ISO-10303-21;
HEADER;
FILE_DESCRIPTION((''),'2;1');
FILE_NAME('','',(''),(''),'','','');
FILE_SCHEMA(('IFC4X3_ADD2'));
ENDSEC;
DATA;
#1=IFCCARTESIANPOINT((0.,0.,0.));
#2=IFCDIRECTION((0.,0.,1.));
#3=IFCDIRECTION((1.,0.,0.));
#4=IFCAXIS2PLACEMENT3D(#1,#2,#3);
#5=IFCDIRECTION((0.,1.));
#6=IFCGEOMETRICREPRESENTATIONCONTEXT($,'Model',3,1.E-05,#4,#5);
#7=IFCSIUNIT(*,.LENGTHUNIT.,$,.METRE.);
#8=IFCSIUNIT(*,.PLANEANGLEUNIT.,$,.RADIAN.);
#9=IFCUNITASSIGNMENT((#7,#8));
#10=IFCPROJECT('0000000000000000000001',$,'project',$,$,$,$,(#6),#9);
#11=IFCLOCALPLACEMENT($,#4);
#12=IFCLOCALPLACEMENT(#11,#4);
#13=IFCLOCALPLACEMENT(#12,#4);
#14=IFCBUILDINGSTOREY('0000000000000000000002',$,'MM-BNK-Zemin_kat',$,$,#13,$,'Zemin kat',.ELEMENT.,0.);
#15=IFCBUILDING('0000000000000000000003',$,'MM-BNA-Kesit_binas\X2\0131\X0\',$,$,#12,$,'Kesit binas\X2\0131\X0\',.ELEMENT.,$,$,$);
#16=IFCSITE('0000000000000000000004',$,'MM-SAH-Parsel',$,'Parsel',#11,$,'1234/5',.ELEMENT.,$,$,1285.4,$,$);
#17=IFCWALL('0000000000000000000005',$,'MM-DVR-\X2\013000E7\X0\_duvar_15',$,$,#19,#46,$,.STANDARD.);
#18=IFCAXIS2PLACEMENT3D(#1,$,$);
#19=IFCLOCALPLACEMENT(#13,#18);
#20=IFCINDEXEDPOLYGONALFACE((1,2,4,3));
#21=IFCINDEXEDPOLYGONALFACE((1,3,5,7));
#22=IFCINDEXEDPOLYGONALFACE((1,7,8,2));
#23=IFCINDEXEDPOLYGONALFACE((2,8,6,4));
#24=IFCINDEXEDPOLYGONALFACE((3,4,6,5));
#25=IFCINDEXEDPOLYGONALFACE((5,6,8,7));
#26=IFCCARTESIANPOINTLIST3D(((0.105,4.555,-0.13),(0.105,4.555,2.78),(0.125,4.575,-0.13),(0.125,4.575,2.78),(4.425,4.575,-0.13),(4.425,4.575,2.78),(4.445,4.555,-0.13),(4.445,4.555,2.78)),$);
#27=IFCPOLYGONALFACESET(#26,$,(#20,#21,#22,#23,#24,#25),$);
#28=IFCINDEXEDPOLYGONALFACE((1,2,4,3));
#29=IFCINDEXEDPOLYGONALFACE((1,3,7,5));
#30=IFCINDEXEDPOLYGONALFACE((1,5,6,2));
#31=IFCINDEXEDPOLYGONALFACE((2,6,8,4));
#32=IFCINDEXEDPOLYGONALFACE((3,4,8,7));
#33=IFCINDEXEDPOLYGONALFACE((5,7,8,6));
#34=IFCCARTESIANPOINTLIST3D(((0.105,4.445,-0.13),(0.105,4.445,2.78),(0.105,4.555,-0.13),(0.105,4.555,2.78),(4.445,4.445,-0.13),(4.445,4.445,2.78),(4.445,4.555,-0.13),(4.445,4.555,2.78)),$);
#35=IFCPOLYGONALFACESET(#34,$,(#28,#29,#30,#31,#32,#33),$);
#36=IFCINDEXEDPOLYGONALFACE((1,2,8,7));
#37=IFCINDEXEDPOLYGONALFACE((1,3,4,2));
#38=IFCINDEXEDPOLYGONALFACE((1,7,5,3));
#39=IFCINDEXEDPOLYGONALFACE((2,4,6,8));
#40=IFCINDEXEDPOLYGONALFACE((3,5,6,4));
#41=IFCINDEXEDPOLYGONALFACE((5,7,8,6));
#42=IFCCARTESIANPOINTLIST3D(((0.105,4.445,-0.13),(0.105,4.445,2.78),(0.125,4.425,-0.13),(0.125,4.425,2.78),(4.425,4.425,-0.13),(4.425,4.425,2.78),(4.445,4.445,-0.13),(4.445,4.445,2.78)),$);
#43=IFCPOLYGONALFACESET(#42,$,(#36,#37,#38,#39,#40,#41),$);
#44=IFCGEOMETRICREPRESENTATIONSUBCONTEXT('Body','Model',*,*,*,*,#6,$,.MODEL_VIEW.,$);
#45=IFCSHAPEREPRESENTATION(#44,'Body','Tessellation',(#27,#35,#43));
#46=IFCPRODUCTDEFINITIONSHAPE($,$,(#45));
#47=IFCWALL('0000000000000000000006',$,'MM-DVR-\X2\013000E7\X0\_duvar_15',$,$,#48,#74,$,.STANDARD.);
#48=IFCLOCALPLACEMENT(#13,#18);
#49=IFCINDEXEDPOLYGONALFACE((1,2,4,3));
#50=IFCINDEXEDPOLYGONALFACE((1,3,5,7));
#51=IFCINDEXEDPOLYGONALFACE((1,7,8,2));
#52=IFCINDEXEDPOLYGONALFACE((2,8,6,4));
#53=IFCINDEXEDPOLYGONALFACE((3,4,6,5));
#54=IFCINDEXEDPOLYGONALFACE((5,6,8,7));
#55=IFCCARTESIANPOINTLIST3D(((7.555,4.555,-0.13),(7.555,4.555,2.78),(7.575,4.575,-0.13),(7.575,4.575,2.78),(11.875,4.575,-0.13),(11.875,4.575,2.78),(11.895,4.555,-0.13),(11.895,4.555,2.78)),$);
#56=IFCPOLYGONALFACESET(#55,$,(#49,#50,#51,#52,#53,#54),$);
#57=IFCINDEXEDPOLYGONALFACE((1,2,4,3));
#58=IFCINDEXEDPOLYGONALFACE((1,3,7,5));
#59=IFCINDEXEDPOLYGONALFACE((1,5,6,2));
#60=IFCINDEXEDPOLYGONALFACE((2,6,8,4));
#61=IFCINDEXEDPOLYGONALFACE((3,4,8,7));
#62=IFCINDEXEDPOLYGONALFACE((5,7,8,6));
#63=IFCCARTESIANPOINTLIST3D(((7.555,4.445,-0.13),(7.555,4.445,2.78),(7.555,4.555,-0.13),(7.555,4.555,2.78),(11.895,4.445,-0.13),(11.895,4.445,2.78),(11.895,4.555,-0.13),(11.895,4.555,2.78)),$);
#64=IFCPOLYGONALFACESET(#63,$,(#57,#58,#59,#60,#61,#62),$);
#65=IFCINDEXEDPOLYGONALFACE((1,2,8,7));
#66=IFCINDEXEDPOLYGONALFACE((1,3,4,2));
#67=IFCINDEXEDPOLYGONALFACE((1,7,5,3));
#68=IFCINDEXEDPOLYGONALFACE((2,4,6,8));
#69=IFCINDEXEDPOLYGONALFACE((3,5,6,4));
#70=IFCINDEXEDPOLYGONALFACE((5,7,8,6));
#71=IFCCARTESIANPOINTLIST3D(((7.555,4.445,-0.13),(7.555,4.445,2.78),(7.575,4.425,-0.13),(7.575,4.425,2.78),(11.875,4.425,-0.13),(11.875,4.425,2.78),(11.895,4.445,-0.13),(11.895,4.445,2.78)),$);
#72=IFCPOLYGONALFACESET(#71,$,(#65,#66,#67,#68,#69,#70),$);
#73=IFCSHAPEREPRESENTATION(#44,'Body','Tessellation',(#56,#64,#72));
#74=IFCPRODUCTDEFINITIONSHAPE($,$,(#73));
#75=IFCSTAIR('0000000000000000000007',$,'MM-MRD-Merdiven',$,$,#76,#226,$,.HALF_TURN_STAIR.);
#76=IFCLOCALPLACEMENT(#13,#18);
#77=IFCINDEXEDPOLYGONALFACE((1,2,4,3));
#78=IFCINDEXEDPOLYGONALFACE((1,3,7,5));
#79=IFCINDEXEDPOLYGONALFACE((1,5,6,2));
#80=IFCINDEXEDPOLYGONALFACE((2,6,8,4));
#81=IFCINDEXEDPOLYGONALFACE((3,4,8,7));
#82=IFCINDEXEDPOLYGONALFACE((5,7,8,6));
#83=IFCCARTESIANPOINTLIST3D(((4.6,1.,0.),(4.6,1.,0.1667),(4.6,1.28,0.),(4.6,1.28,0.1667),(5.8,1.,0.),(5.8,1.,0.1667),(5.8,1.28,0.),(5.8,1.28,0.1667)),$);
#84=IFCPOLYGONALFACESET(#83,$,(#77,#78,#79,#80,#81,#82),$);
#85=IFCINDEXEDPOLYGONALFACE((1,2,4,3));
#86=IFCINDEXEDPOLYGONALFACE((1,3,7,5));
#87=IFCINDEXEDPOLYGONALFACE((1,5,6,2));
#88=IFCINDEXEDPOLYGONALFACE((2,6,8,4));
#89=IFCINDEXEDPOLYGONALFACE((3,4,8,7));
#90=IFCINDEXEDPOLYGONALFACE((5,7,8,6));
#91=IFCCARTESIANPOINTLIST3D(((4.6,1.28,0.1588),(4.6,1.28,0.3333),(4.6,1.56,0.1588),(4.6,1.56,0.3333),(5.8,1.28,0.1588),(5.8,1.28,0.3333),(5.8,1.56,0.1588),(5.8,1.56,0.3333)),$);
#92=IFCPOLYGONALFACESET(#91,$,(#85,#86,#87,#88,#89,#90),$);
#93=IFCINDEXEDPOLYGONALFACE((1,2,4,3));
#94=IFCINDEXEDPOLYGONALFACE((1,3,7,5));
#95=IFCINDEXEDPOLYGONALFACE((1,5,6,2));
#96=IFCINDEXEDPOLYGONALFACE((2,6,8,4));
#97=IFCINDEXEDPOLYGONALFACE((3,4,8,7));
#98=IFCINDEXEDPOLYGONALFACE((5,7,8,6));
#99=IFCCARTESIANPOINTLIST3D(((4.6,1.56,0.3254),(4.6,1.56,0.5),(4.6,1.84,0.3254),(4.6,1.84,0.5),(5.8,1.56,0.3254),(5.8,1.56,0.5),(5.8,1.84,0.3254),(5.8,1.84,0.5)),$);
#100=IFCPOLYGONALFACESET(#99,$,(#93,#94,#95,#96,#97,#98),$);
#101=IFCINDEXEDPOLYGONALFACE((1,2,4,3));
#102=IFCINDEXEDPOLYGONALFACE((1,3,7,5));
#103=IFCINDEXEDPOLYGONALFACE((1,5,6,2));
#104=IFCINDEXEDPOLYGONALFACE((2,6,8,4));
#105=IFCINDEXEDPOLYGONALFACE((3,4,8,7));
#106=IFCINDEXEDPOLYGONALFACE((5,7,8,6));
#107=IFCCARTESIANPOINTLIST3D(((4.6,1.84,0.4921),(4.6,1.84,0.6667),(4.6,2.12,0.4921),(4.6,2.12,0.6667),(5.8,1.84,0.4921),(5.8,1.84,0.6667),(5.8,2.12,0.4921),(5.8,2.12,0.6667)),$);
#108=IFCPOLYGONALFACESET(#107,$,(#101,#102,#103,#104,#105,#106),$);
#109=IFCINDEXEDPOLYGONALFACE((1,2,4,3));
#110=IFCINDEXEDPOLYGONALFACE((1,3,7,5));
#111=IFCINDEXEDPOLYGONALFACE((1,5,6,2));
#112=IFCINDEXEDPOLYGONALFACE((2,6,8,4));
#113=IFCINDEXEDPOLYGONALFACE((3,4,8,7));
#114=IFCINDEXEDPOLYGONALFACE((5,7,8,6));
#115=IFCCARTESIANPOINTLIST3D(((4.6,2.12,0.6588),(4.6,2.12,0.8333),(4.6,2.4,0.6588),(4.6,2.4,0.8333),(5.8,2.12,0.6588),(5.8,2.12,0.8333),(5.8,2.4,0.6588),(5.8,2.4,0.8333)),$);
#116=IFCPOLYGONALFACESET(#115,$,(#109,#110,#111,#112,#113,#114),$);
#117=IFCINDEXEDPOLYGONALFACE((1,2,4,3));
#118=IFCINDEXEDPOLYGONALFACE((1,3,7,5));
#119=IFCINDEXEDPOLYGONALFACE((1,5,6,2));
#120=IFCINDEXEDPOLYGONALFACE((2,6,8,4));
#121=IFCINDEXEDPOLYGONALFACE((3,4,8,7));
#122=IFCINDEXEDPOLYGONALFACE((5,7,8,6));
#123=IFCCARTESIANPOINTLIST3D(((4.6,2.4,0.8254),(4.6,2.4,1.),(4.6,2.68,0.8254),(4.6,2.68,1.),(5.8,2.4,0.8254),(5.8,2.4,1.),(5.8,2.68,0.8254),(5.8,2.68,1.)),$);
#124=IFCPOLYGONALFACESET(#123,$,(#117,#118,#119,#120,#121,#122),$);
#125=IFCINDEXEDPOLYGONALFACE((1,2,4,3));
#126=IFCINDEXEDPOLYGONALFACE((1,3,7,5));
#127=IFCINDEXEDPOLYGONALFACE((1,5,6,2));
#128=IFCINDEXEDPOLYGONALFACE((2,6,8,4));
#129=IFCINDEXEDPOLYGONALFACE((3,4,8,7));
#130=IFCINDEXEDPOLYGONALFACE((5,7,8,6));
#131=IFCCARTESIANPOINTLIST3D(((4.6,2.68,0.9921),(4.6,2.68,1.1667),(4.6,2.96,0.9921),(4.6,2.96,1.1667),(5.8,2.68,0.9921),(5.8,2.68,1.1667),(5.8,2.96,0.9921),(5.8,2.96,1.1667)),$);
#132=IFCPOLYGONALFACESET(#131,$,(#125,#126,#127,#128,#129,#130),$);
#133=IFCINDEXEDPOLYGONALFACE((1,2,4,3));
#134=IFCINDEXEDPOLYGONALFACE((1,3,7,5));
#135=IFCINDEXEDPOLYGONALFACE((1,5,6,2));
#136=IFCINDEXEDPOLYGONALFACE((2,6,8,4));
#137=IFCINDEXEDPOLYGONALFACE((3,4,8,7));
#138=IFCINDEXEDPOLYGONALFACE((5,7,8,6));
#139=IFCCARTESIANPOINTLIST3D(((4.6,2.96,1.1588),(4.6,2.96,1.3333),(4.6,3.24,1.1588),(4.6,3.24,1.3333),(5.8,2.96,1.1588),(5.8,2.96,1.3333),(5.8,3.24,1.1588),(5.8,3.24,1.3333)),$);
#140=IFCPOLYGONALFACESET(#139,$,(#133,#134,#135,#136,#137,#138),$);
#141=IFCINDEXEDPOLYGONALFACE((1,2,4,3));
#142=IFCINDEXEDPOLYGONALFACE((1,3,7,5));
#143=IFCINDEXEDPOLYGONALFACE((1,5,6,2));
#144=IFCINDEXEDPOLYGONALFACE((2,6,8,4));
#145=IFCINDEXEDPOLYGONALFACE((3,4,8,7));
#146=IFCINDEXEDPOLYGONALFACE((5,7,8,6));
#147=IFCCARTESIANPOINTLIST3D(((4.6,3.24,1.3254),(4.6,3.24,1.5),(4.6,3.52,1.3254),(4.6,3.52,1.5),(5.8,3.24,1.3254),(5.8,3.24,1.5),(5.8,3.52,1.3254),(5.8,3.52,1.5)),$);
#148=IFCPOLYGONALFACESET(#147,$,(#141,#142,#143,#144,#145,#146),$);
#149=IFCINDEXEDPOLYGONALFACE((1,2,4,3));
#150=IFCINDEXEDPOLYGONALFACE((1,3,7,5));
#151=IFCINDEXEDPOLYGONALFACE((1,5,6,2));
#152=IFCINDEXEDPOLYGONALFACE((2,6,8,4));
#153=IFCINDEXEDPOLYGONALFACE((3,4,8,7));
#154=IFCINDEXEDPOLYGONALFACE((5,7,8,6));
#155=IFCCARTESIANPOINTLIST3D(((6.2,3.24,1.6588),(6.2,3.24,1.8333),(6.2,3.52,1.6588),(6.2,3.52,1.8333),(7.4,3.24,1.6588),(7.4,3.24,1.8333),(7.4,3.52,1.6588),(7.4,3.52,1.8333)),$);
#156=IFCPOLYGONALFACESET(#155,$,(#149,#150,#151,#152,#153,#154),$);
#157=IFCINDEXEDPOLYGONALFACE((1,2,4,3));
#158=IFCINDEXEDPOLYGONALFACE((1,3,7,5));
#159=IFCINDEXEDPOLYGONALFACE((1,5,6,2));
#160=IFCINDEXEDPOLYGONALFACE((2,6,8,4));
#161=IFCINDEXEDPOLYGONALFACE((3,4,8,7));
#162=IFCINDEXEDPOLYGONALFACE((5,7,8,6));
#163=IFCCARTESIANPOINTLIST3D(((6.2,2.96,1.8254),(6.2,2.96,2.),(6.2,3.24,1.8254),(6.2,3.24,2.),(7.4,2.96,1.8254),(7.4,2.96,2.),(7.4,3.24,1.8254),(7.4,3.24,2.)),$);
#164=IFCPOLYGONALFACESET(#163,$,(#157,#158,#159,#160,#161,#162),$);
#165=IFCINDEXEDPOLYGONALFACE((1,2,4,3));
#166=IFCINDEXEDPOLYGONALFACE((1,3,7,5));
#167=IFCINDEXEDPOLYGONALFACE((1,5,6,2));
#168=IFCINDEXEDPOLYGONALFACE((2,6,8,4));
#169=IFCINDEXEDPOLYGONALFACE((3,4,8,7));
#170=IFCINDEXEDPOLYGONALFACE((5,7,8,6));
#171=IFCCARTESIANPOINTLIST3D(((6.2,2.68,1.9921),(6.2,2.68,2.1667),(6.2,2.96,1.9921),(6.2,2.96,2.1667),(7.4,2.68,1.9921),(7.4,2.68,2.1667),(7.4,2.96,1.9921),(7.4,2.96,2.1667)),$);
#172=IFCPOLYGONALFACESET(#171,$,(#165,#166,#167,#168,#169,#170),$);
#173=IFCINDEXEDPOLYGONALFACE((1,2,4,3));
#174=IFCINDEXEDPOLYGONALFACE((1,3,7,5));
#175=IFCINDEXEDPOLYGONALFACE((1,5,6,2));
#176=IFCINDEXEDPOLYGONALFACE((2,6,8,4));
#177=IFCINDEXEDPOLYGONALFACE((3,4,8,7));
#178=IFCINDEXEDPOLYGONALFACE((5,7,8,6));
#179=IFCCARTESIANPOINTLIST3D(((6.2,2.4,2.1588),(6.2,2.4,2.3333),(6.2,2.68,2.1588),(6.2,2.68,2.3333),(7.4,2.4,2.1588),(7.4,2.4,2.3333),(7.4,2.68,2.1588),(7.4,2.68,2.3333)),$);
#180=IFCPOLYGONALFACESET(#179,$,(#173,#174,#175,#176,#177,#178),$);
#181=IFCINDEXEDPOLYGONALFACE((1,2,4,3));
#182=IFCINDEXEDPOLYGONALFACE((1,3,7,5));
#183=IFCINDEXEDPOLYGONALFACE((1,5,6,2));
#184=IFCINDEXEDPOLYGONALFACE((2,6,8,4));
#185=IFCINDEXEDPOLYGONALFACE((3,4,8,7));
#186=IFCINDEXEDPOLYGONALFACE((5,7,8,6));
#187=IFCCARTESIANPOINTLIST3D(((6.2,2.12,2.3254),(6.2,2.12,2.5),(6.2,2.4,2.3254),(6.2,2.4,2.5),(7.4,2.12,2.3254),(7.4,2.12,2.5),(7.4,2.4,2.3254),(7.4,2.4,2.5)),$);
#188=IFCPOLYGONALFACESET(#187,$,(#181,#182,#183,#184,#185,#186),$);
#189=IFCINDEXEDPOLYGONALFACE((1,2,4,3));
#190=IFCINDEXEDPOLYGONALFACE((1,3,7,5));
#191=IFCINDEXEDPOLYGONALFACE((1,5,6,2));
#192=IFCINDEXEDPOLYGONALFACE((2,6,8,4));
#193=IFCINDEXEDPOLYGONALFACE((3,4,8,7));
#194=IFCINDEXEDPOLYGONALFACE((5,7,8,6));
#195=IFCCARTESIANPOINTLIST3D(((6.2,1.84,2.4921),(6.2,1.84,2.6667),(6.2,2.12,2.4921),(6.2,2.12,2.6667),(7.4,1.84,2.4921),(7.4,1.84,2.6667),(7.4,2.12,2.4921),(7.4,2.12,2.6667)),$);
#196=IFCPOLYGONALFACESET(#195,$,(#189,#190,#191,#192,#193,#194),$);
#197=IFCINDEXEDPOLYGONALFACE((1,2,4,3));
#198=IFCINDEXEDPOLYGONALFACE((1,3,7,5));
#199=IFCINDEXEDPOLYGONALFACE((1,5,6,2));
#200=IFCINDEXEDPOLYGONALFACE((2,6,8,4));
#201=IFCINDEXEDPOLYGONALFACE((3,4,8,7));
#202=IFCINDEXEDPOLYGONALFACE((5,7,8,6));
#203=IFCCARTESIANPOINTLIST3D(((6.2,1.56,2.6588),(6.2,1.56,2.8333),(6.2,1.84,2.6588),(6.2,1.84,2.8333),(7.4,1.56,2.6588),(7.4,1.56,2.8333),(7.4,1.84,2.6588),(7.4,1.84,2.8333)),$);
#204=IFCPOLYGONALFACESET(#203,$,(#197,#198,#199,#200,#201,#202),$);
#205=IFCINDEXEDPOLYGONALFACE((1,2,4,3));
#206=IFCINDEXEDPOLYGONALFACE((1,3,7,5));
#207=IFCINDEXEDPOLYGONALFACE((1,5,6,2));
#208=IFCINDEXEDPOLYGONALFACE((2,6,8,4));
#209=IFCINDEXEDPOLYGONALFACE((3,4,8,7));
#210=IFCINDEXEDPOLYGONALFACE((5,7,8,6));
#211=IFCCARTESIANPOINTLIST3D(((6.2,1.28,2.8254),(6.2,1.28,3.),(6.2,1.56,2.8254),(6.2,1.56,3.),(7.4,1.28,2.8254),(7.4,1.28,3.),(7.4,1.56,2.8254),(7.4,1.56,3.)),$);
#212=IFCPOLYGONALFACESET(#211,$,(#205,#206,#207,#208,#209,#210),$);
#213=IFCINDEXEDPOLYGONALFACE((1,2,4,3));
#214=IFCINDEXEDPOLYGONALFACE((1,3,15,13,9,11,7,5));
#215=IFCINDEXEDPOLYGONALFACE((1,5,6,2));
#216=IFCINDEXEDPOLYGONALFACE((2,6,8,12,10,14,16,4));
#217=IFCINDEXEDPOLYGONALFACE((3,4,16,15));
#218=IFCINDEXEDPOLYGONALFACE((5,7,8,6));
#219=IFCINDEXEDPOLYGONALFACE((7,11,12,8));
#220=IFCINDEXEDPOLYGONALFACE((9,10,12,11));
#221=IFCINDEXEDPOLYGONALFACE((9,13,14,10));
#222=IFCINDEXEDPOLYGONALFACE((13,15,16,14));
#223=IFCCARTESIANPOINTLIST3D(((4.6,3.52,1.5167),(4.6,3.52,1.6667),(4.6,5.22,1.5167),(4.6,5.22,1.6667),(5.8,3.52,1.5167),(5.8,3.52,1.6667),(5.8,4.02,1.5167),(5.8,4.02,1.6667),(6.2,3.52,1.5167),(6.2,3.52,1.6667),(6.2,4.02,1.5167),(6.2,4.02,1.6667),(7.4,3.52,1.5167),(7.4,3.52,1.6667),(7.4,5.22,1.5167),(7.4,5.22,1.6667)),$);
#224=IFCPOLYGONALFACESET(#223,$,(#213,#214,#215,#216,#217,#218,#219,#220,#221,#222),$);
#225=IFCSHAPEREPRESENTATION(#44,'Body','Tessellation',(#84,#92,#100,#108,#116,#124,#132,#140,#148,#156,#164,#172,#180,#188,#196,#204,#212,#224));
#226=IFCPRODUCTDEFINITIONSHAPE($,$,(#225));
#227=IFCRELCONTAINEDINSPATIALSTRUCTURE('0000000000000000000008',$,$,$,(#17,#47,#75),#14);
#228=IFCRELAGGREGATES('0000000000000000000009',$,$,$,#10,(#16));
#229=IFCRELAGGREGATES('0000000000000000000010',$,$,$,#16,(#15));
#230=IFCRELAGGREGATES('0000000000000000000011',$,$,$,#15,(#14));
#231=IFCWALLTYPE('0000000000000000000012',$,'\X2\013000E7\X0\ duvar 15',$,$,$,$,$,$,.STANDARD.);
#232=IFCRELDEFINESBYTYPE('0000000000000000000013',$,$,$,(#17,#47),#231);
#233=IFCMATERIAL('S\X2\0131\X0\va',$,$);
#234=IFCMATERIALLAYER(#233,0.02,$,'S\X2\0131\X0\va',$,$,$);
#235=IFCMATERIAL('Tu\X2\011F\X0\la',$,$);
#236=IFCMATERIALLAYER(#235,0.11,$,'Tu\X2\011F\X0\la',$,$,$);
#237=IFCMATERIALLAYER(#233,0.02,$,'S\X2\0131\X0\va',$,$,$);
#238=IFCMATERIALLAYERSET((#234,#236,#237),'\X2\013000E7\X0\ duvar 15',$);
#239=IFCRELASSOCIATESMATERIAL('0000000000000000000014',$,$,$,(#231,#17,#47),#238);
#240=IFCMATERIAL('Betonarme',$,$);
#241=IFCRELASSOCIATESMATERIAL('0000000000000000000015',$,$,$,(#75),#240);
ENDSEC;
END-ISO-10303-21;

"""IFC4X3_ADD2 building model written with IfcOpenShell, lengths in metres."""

from ifc_helpers import new_model, si_unit, direction, frame, origin, origin_with_axes, place, context, subcontext, project, spatial, polyline, outline, extrude, material, layer, layer_set, type_object, element, save


model = new_model("IFC4X3_ADD2")

# Units and contexts
model_context = context("Model", 3, precision=1e-05, world=origin_with_axes(), true_north=direction((0.0, 1.0)))
body_context = subcontext(model_context, "Body", "Model", "MODEL_VIEW")
ifc_project = project(units=[si_unit("LENGTHUNIT", "METRE"), si_unit("PLANEANGLEUNIT", "RADIAN")], contexts=[model_context])

# Site, building, storey
site_placement = place(None, origin_with_axes())
site = spatial("IfcSite", under=ifc_project, at=site_placement, Name="MM-SAH-Parsel", ObjectType="Parsel", LongName="1234/5", CompositionType="ELEMENT", RefElevation=1285.4)
building_placement = place(site_placement, origin_with_axes())
building = spatial("IfcBuilding", under=site, at=building_placement, Name="MM-BNA-Kesit_binası", LongName="Kesit binası", CompositionType="ELEMENT")
storey_placement = place(building_placement, origin_with_axes())
storey = spatial("IfcBuildingStorey", under=building, at=storey_placement, Name="MM-BNK-Zemin_kat", LongName="Zemin kat", CompositionType="ELEMENT", Elevation=0.0)

# Shared definitions
ifc_material_1 = material(Name="Betonarme")

# Shared definitions
ifc_material_2 = material(Name="Tuğla")

# Shared definitions
ifc_material_3 = material(Name="Sıva")
ifc_layer_1 = layer(ifc_material_3, 0.02, Name="Sıva")
ifc_layer_2 = layer(ifc_material_2, 0.11, Name="Tuğla")
ifc_layer_3 = layer(ifc_material_3, 0.02, Name="Sıva")
ifc_layer_set_1 = layer_set([ifc_layer_1, ifc_layer_2, ifc_layer_3], Name="İç duvar 15")
wall_type_1 = type_object("IfcWallType", Name="İç duvar 15", PredefinedType="STANDARD", material=ifc_layer_set_1)

# Walls
wall_1_placement = place(storey_placement, origin_with_axes())
element("IfcWall", 1, at=wall_1_placement, inside=storey, type_object=wall_type_1, material=ifc_layer_set_1, Name="MM-DVR-İç_duvar_15", PredefinedType="STANDARD", context=body_context, shape_type="SweptSolid", body=[
    extrude(outline(polyline([(0.125, 4.575), (4.425, 4.575), (4.445, 4.555), (0.105, 4.555), (0.125, 4.575)])), frame((0.0, 0.0, -0.13)), (0.0, 0.0, 1.0), 2.91),
    extrude(outline(polyline([(0.105, 4.555), (4.445, 4.555), (4.445, 4.445), (0.105, 4.445), (0.105, 4.555)])), frame((0.0, 0.0, -0.13)), (0.0, 0.0, 1.0), 2.91),
    extrude(outline(polyline([(0.105, 4.445), (4.445, 4.445), (4.425, 4.425), (0.125, 4.425), (0.105, 4.445)])), frame((0.0, 0.0, -0.13)), (0.0, 0.0, 1.0), 2.91),
])
wall_2_placement = place(storey_placement, origin_with_axes())
element("IfcWall", 2, at=wall_2_placement, inside=storey, type_object=wall_type_1, material=ifc_layer_set_1, Name="MM-DVR-İç_duvar_15", PredefinedType="STANDARD", context=body_context, shape_type="SweptSolid", body=[
    extrude(outline(polyline([(7.575, 4.575), (11.875, 4.575), (11.895, 4.555), (7.555, 4.555), (7.575, 4.575)])), frame((0.0, 0.0, -0.13)), (0.0, 0.0, 1.0), 2.91),
    extrude(outline(polyline([(7.555, 4.555), (11.895, 4.555), (11.895, 4.445), (7.555, 4.445), (7.555, 4.555)])), frame((0.0, 0.0, -0.13)), (0.0, 0.0, 1.0), 2.91),
    extrude(outline(polyline([(7.555, 4.445), (11.895, 4.445), (11.875, 4.425), (7.575, 4.425), (7.555, 4.445)])), frame((0.0, 0.0, -0.13)), (0.0, 0.0, 1.0), 2.91),
])

# Stair
stair_placement = place(storey_placement, origin_with_axes())
element("IfcStair", 3, at=stair_placement, inside=storey, material=ifc_material_1, Name="MM-MRD-Merdiven", PredefinedType="HALF_TURN_STAIR", context=body_context, shape_type="SweptSolid", body=[
    extrude(outline(polyline([(5.8, 1.0), (5.8, 1.28), (4.6, 1.28), (4.6, 1.0), (5.8, 1.0)])), origin(), (0.0, 0.0, 1.0), 0.1667),
    extrude(outline(polyline([(5.8, 1.28), (5.8, 1.56), (4.6, 1.56), (4.6, 1.28), (5.8, 1.28)])), frame((0.0, 0.0, 0.1588)), (0.0, 0.0, 1.0), 0.1746),
    extrude(outline(polyline([(5.8, 1.56), (5.8, 1.84), (4.6, 1.84), (4.6, 1.56), (5.8, 1.56)])), frame((0.0, 0.0, 0.3254)), (0.0, 0.0, 1.0), 0.1746),
    extrude(outline(polyline([(5.8, 1.84), (5.8, 2.12), (4.6, 2.12), (4.6, 1.84), (5.8, 1.84)])), frame((0.0, 0.0, 0.4921)), (0.0, 0.0, 1.0), 0.1746),
    extrude(outline(polyline([(5.8, 2.12), (5.8, 2.4), (4.6, 2.4), (4.6, 2.12), (5.8, 2.12)])), frame((0.0, 0.0, 0.6588)), (0.0, 0.0, 1.0), 0.1746),
    extrude(outline(polyline([(5.8, 2.4), (5.8, 2.68), (4.6, 2.68), (4.6, 2.4), (5.8, 2.4)])), frame((0.0, 0.0, 0.8254)), (0.0, 0.0, 1.0), 0.1746),
    extrude(outline(polyline([(5.8, 2.68), (5.8, 2.96), (4.6, 2.96), (4.6, 2.68), (5.8, 2.68)])), frame((0.0, 0.0, 0.9921)), (0.0, 0.0, 1.0), 0.1746),
    extrude(outline(polyline([(5.8, 2.96), (5.8, 3.24), (4.6, 3.24), (4.6, 2.96), (5.8, 2.96)])), frame((0.0, 0.0, 1.1588)), (0.0, 0.0, 1.0), 0.1746),
    extrude(outline(polyline([(5.8, 3.24), (5.8, 3.52), (4.6, 3.52), (4.6, 3.24), (5.8, 3.24)])), frame((0.0, 0.0, 1.3254)), (0.0, 0.0, 1.0), 0.1746),
    extrude(outline(polyline([(6.2, 3.52), (6.2, 3.24), (7.4, 3.24), (7.4, 3.52), (6.2, 3.52)])), frame((0.0, 0.0, 1.6588)), (0.0, 0.0, 1.0), 0.1746),
    extrude(outline(polyline([(6.2, 3.24), (6.2, 2.96), (7.4, 2.96), (7.4, 3.24), (6.2, 3.24)])), frame((0.0, 0.0, 1.8254)), (0.0, 0.0, 1.0), 0.1746),
    extrude(outline(polyline([(6.2, 2.96), (6.2, 2.68), (7.4, 2.68), (7.4, 2.96), (6.2, 2.96)])), frame((0.0, 0.0, 1.9921)), (0.0, 0.0, 1.0), 0.1746),
    extrude(outline(polyline([(6.2, 2.68), (6.2, 2.4), (7.4, 2.4), (7.4, 2.68), (6.2, 2.68)])), frame((0.0, 0.0, 2.1588)), (0.0, 0.0, 1.0), 0.1746),
    extrude(outline(polyline([(6.2, 2.4), (6.2, 2.12), (7.4, 2.12), (7.4, 2.4), (6.2, 2.4)])), frame((0.0, 0.0, 2.3254)), (0.0, 0.0, 1.0), 0.1746),
    extrude(outline(polyline([(6.2, 2.12), (6.2, 1.84), (7.4, 1.84), (7.4, 2.12), (6.2, 2.12)])), frame((0.0, 0.0, 2.4921)), (0.0, 0.0, 1.0), 0.1746),
    extrude(outline(polyline([(6.2, 1.84), (6.2, 1.56), (7.4, 1.56), (7.4, 1.84), (6.2, 1.84)])), frame((0.0, 0.0, 2.6588)), (0.0, 0.0, 1.0), 0.1746),
    extrude(outline(polyline([(6.2, 1.56), (6.2, 1.28), (7.4, 1.28), (7.4, 1.56), (6.2, 1.56)])), frame((0.0, 0.0, 2.8254)), (0.0, 0.0, 1.0), 0.1746),
    extrude(outline(polyline([(4.6, 3.52), (4.6, 5.22), (7.4, 5.22), (7.4, 3.52), (6.2, 3.52), (6.2, 4.02), (5.8, 4.02), (5.8, 3.52), (4.6, 3.52)])), frame((0.0, 0.0, 1.5167)), (0.0, 0.0, 1.0), 0.15),
])

save(model, "model.ifc")
